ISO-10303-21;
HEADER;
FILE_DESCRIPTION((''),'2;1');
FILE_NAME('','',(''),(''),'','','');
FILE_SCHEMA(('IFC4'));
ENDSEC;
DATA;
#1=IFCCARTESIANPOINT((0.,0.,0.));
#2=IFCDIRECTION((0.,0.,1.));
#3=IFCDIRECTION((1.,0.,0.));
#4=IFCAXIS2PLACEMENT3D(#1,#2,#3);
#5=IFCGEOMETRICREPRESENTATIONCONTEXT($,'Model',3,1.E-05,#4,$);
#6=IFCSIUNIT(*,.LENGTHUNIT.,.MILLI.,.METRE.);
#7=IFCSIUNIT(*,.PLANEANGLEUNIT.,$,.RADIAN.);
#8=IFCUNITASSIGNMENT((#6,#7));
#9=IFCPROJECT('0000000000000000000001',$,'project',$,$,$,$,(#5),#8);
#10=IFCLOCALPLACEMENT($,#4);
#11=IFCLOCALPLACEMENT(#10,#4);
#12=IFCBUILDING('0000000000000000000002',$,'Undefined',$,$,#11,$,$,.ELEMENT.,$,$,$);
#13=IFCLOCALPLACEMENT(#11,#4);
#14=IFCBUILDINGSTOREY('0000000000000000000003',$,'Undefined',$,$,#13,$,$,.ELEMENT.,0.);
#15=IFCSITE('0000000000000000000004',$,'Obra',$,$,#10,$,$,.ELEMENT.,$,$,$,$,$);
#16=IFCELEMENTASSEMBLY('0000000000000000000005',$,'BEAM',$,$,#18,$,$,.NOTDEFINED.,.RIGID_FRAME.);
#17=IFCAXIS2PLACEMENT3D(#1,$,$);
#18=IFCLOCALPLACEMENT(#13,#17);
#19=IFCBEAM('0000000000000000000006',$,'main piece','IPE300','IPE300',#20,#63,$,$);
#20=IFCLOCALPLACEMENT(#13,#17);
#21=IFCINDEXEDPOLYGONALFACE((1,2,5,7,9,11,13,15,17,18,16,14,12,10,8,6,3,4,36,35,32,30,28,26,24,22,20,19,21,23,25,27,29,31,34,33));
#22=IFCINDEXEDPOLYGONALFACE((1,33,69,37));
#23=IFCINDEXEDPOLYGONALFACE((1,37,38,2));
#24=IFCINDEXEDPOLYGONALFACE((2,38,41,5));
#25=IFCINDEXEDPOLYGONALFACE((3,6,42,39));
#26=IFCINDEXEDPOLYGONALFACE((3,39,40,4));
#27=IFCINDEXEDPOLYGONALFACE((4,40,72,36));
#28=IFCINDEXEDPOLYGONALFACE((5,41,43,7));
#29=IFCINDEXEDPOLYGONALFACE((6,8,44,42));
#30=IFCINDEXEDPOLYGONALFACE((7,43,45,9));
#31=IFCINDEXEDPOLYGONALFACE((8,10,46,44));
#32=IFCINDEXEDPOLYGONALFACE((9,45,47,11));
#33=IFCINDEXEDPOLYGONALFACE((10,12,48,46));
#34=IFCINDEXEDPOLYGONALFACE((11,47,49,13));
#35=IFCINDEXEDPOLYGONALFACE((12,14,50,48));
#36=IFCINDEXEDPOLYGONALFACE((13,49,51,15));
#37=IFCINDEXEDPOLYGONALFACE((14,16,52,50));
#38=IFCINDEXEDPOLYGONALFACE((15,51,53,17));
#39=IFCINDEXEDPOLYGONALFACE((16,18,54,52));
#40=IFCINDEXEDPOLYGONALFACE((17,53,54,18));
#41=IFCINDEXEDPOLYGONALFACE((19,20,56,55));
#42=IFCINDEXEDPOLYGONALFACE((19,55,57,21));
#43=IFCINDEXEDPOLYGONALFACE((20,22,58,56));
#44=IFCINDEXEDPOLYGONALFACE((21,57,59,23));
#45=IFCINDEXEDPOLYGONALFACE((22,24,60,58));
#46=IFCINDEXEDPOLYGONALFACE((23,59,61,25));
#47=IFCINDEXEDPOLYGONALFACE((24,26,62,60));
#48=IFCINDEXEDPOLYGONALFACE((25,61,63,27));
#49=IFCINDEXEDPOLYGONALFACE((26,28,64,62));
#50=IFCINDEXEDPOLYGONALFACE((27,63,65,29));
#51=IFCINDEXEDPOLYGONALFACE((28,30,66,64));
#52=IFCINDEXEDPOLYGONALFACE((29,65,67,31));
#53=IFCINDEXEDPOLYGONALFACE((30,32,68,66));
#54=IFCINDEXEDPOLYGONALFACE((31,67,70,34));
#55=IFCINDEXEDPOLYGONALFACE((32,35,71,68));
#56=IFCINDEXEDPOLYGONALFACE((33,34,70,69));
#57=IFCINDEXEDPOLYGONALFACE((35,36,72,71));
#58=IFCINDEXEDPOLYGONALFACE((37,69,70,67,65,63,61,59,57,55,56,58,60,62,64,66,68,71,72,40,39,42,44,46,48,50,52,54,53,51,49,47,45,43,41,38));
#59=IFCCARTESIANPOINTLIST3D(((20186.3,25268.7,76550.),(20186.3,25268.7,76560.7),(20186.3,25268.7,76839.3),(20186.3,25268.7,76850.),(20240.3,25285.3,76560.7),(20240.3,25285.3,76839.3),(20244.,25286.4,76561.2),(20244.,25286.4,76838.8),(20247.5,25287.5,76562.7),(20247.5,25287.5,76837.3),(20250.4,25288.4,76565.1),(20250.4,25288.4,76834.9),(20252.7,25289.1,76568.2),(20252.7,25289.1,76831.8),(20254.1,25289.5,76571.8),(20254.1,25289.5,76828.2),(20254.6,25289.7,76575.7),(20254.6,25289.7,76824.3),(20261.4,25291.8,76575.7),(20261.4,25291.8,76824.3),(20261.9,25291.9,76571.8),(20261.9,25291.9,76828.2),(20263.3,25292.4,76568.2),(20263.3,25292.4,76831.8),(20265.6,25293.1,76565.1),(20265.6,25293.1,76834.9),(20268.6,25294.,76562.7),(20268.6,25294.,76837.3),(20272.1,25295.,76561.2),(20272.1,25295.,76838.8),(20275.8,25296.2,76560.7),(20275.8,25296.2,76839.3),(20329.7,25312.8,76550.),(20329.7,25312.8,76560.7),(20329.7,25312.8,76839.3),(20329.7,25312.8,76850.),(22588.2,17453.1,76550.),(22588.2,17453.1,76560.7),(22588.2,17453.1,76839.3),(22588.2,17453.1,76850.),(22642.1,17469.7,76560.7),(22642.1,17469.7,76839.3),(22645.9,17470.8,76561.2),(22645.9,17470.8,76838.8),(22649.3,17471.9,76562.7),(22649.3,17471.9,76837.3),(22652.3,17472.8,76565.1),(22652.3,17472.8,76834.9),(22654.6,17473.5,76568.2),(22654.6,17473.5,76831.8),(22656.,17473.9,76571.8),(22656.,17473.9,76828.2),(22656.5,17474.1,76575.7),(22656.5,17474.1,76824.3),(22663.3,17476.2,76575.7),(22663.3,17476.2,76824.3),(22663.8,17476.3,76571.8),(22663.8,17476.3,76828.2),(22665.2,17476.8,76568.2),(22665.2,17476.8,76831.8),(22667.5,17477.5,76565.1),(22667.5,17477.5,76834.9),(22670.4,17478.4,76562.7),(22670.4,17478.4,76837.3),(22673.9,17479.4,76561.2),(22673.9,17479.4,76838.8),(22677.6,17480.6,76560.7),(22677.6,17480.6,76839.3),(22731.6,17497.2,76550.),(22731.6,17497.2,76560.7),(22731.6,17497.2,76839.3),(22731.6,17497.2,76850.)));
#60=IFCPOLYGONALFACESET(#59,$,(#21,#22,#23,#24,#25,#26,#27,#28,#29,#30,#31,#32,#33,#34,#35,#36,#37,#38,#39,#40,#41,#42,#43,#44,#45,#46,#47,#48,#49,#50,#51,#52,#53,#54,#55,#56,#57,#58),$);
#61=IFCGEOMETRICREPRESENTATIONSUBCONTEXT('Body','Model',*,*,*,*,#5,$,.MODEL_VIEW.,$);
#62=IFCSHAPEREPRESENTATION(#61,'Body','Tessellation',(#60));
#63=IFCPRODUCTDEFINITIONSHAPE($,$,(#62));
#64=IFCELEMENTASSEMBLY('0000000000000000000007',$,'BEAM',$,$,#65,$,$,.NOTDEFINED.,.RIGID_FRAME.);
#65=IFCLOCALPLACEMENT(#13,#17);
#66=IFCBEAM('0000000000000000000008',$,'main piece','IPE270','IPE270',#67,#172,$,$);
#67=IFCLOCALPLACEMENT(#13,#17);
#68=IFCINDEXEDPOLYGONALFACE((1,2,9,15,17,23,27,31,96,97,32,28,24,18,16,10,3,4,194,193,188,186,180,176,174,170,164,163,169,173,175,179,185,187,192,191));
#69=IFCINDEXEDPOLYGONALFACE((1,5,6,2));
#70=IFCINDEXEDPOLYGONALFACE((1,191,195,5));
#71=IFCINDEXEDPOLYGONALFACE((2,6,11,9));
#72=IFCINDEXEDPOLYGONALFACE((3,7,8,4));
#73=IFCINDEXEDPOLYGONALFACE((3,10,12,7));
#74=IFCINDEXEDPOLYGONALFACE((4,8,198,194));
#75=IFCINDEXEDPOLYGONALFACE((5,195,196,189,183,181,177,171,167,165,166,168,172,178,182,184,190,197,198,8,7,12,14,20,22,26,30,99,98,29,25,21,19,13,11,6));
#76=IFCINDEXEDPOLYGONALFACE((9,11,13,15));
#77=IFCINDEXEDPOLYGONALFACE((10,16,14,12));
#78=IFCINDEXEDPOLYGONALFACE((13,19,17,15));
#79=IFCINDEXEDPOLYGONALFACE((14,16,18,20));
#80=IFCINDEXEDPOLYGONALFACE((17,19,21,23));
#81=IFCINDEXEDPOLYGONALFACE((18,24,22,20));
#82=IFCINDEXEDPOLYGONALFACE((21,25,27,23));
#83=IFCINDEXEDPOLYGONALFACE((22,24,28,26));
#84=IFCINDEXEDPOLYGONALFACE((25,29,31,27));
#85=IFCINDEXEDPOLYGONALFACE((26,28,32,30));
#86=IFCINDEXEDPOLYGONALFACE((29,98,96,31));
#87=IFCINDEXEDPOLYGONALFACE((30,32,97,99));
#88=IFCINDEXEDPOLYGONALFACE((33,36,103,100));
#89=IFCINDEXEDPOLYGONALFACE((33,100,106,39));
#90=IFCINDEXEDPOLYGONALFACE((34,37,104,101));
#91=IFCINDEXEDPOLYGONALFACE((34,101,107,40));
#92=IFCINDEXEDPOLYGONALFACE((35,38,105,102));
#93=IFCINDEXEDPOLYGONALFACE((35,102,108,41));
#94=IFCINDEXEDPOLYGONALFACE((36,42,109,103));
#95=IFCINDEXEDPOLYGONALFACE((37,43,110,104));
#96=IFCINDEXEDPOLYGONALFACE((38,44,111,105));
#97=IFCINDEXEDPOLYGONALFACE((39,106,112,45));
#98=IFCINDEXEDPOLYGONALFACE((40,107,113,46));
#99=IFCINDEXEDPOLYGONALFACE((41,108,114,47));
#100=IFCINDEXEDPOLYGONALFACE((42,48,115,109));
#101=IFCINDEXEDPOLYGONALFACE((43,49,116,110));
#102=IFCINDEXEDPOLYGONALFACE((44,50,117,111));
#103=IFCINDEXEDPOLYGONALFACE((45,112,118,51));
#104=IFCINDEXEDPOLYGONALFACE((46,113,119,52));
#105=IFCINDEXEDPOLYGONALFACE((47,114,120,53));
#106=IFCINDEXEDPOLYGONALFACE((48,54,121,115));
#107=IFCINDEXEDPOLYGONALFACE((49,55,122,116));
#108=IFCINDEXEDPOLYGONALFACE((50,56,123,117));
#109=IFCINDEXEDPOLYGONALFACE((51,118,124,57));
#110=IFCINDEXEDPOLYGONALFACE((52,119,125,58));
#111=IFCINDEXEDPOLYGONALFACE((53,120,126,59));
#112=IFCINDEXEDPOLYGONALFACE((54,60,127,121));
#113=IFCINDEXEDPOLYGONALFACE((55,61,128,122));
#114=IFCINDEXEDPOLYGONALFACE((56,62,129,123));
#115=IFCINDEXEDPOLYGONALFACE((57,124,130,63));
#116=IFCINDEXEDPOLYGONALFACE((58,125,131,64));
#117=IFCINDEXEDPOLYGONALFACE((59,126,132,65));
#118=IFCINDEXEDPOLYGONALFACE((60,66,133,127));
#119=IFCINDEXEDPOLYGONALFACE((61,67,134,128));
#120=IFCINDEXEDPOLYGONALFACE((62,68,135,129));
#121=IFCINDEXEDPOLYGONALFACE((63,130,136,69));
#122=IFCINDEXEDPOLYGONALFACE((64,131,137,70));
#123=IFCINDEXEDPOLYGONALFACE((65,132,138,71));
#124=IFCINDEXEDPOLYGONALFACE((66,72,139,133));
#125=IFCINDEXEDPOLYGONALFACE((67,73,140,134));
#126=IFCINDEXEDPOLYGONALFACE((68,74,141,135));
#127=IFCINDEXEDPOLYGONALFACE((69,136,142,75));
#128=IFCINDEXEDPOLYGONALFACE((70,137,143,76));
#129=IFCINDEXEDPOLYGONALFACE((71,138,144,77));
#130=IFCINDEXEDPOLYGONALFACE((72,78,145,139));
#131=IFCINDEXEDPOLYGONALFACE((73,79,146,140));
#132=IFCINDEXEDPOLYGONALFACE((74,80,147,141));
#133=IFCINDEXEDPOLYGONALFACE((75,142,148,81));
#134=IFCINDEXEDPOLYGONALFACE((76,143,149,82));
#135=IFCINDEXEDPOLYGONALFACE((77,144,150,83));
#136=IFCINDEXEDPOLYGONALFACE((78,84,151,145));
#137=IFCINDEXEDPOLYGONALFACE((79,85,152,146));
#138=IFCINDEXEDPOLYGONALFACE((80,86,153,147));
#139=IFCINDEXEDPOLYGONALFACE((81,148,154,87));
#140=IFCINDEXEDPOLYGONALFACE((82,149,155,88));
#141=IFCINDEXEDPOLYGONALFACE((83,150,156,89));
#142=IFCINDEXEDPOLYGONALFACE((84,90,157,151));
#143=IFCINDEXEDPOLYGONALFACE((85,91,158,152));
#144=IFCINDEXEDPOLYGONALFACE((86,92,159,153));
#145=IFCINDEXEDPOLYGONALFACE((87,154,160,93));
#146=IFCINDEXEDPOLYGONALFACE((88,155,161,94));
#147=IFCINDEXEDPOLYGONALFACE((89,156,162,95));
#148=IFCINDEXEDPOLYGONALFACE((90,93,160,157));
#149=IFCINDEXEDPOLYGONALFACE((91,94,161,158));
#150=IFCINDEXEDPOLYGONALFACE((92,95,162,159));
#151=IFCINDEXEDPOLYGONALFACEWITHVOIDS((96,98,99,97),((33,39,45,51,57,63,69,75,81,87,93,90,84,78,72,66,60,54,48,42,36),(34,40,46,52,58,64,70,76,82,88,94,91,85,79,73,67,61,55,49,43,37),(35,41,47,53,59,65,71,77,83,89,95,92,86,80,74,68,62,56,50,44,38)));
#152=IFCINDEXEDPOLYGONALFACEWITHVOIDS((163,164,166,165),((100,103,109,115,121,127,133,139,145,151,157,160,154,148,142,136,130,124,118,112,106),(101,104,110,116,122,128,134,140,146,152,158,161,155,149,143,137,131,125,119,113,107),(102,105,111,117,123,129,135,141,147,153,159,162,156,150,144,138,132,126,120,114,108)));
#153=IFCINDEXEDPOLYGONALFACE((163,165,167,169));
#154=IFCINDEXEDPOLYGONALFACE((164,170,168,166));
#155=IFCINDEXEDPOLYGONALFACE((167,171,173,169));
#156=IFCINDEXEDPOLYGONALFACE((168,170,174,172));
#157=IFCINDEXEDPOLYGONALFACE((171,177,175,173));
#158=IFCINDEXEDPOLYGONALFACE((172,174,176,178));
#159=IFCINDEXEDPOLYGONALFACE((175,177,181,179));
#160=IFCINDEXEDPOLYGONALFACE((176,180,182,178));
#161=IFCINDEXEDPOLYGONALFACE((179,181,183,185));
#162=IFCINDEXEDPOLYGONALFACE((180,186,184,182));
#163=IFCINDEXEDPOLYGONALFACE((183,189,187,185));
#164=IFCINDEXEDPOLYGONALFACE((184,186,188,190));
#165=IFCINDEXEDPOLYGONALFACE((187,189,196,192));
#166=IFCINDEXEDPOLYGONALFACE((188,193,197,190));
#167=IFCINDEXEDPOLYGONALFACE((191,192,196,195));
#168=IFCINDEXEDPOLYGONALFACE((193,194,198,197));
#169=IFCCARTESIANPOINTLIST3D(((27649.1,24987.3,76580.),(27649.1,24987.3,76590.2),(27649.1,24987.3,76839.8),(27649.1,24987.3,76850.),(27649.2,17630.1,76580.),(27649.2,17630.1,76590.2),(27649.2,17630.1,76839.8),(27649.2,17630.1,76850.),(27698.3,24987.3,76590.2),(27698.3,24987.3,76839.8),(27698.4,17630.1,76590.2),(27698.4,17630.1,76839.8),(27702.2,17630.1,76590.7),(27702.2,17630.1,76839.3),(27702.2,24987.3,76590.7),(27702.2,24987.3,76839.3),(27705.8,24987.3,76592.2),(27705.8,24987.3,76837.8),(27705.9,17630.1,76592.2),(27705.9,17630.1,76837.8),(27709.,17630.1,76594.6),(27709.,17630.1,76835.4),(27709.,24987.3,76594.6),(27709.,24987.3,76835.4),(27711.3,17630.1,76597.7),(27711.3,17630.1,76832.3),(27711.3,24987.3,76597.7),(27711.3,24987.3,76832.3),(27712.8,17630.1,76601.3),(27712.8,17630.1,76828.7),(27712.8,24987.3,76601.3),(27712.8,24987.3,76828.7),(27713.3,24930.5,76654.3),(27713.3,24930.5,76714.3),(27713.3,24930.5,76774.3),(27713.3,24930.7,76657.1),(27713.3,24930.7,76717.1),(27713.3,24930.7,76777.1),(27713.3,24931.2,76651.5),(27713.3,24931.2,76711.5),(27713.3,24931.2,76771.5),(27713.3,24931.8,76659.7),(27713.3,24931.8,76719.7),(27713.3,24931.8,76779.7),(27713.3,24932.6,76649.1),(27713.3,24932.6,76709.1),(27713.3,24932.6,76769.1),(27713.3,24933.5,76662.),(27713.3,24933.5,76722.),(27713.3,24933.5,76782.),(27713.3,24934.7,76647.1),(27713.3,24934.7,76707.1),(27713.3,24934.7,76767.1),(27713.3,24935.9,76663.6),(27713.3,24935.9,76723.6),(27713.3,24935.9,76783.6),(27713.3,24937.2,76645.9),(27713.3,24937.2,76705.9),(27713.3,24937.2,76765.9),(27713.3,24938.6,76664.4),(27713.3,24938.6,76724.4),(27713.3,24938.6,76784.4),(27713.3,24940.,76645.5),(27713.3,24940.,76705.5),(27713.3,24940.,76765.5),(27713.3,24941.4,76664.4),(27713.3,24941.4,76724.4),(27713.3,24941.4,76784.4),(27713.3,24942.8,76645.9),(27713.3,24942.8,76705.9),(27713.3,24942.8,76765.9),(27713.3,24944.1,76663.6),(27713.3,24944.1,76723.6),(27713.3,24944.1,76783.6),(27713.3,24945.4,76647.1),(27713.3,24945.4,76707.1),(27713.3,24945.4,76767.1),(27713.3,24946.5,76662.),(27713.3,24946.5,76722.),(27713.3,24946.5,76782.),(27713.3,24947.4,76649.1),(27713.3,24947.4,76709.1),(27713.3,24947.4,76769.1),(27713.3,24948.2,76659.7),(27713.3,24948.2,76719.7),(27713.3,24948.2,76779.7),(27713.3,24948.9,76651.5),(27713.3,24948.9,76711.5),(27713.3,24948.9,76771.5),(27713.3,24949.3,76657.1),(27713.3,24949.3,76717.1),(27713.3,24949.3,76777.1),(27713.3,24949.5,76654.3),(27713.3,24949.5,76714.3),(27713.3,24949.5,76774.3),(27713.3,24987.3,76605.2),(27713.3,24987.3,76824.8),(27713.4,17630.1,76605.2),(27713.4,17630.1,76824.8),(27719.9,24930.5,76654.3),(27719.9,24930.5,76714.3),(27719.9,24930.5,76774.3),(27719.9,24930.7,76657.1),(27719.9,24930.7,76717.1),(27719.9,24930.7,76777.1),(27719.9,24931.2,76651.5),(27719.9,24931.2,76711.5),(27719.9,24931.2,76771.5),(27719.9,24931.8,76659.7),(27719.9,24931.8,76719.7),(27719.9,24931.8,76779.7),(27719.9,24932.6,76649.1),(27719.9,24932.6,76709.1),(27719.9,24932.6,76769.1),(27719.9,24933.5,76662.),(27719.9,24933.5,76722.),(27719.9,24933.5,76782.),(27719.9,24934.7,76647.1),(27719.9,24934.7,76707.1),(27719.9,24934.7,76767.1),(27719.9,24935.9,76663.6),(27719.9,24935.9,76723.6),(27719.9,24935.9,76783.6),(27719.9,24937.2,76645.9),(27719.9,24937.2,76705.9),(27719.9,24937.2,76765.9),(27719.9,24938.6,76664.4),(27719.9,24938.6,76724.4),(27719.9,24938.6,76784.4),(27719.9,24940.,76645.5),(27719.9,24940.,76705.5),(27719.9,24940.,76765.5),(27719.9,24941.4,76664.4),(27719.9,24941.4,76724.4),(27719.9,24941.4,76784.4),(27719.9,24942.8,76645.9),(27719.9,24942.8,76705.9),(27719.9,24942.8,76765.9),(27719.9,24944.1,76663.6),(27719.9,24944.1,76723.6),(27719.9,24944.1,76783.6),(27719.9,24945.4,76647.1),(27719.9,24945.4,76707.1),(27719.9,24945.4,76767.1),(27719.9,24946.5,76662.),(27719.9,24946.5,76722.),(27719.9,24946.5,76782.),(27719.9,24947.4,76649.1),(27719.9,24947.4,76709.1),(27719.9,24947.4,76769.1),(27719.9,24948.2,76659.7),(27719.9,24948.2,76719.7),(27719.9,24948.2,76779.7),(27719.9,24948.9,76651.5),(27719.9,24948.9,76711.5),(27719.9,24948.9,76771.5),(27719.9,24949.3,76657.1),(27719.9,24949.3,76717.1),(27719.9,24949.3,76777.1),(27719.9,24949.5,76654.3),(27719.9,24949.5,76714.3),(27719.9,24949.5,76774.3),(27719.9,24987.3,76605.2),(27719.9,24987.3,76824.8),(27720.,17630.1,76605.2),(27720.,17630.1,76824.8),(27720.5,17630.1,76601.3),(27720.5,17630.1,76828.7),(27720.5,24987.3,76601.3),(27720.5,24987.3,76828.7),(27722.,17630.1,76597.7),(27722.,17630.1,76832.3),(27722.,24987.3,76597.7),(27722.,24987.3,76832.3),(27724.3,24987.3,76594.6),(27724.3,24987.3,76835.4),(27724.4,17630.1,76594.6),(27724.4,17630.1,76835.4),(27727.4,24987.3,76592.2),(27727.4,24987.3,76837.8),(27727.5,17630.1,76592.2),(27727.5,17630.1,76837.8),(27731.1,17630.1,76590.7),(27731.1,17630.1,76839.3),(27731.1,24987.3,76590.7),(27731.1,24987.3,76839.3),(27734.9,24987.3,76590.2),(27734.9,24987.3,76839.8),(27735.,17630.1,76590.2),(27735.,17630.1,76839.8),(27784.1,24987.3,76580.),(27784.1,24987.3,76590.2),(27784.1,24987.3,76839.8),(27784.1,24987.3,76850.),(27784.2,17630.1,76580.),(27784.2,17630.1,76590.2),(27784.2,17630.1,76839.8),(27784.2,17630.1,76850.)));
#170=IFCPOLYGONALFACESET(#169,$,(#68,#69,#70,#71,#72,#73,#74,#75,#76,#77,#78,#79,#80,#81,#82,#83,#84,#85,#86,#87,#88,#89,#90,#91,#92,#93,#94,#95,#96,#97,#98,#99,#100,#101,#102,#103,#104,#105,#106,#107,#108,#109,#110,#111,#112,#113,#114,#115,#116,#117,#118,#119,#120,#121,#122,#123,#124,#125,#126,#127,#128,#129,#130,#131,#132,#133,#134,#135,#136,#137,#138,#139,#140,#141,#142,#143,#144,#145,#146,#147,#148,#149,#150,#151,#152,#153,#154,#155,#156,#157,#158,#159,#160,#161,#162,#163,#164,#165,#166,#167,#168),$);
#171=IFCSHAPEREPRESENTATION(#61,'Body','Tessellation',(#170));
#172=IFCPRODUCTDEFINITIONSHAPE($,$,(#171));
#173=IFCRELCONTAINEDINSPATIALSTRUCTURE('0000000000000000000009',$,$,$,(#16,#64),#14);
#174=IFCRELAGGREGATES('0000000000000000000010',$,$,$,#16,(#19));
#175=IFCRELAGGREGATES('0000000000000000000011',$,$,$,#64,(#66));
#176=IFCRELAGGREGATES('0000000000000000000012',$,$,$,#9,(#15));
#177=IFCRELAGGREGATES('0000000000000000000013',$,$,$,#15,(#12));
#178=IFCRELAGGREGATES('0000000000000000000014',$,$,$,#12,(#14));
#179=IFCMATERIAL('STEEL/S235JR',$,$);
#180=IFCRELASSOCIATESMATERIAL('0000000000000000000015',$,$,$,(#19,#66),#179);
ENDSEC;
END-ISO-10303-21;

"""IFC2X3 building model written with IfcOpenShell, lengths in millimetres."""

from ifc_helpers import new_model, si_unit, frame, origin_with_axes, origin_2d_with_axis, place, context, subcontext, project, spatial, circle, i_section, extrude, clip, halfspace, source, transform, mapped, material, element, aggregate, save


model = new_model("IFC2X3")

# Units and contexts
model_context = context("Model", 3, precision=1e-05, world=origin_with_axes())
body_context = subcontext(model_context, "Body", "Model", "MODEL_VIEW")
ifc_project = project(units=[si_unit("LENGTHUNIT", "METRE", prefix="MILLI"), si_unit("PLANEANGLEUNIT", "RADIAN")], contexts=[model_context])

# Site, building, storey
site_placement = place(None, origin_with_axes())
site = spatial("IfcSite", under=ifc_project, at=site_placement, Name="Obra", CompositionType="ELEMENT")
building_placement = place(site_placement, origin_with_axes())
building = spatial("IfcBuilding", under=site, at=building_placement, Name="Undefined", CompositionType="ELEMENT")
storey_placement = place(building_placement, origin_with_axes())
storey = spatial("IfcBuildingStorey", under=building, at=storey_placement, Name="Undefined", CompositionType="ELEMENT", Elevation=0.0)

# Shared definitions
ifc_material = material(Name="STEEL/S235JR")

# Element assembly, beam
assembly_1_placement = place(storey_placement, origin_with_axes())
assembly_1 = element("IfcElementAssembly", 1, at=assembly_1_placement, inside=storey, Name="BEAM", AssemblyPlace="NOTDEFINED", PredefinedType="RIGID_FRAME")
beam_1_placement = place(assembly_1_placement, frame((22659.9, 17475.1, 76700.0), z_axis=(0.0, 0.0, 1.0), x_axis=(-0.293756, 0.955881, 0.0)))
beam_1 = element("IfcBeam", 2, at=beam_1_placement, material=ifc_material, Name="main piece", Description="IPE300", ObjectType="IPE300", context=body_context, shape_type="SweptSolid", body=[
    extrude(i_section(OverallWidth=150.0, OverallDepth=300.0, WebThickness=7.1, FlangeThickness=10.7, FilletRadius=15.0, at=origin_2d_with_axis()), frame((8176.3, 0.0, 0.0), z_axis=(-1.0, 0.0, 0.0), x_axis=(0.0, -1.0, 0.0)), (0.0, 0.0, 1.0), 8176.3),
])
aggregate(assembly_1, [beam_1])

# Element assembly, beam, opening
assembly_2_placement = place(storey_placement, origin_with_axes())
assembly_2 = element("IfcElementAssembly", 3, at=assembly_2_placement, inside=storey, Name="BEAM", AssemblyPlace="NOTDEFINED", PredefinedType="RIGID_FRAME")
beam_2_placement = place(assembly_2_placement, frame((27716.7, 17630.1, 76715.0), z_axis=(0.0, 0.0, 1.0), x_axis=(-0.000002, 1.0, 0.0)))
beam_2 = element("IfcBeam", 4, at=beam_2_placement, material=ifc_material, Name="main piece", Description="IPE270", ObjectType="IPE270", context=body_context, shape_type="Clipping", body=[
    clip(extrude(i_section(OverallWidth=135.0, OverallDepth=270.0, WebThickness=6.6, FlangeThickness=10.2, FilletRadius=15.0, at=origin_2d_with_axis()), frame((7357.1, 0.0, 0.0), z_axis=(-1.0, 0.0, 0.0), x_axis=(0.0, -1.0, 0.0)), (0.0, 0.0, 1.0), 7357.1), halfspace(frame((7359.4, -60.0, -120.0), z_axis=(1.0, 0.000019, 0.0), x_axis=(0.0, 0.0, 1.0)), False)),
])
shared_shape_1 = source(origin_with_axes(), body_context, "Body", "SweptSolid", [
    extrude(circle(Radius=9.5, at=origin_2d_with_axis()), frame((0.0, -3.4, 0.0), z_axis=(0.0, 1.0, 0.0), x_axis=(1.0, 0.0, 0.0)), (0.0, 0.0, 1.0), 6.8),
])
opening_1_placement = place(assembly_2_placement, frame((27716.6, 24990.0, 76835.0), z_axis=(0.000002, -1.0, 0.0), x_axis=(0.0, 0.0, -1.0)))
element("IfcOpeningElement", 5, at=opening_1_placement, cuts=beam_2, ObjectType="Opening", context=body_context, shape_type="MappedRepresentation", body=[
    mapped(shared_shape_1, transform((60.0, 0.0, 50.0))),
    mapped(shared_shape_1, transform((120.0, 0.0, 50.0))),
    mapped(shared_shape_1, transform((180.0, 0.0, 50.0))),
])
aggregate(assembly_2, [beam_2])

save(model, "model.ifc")
